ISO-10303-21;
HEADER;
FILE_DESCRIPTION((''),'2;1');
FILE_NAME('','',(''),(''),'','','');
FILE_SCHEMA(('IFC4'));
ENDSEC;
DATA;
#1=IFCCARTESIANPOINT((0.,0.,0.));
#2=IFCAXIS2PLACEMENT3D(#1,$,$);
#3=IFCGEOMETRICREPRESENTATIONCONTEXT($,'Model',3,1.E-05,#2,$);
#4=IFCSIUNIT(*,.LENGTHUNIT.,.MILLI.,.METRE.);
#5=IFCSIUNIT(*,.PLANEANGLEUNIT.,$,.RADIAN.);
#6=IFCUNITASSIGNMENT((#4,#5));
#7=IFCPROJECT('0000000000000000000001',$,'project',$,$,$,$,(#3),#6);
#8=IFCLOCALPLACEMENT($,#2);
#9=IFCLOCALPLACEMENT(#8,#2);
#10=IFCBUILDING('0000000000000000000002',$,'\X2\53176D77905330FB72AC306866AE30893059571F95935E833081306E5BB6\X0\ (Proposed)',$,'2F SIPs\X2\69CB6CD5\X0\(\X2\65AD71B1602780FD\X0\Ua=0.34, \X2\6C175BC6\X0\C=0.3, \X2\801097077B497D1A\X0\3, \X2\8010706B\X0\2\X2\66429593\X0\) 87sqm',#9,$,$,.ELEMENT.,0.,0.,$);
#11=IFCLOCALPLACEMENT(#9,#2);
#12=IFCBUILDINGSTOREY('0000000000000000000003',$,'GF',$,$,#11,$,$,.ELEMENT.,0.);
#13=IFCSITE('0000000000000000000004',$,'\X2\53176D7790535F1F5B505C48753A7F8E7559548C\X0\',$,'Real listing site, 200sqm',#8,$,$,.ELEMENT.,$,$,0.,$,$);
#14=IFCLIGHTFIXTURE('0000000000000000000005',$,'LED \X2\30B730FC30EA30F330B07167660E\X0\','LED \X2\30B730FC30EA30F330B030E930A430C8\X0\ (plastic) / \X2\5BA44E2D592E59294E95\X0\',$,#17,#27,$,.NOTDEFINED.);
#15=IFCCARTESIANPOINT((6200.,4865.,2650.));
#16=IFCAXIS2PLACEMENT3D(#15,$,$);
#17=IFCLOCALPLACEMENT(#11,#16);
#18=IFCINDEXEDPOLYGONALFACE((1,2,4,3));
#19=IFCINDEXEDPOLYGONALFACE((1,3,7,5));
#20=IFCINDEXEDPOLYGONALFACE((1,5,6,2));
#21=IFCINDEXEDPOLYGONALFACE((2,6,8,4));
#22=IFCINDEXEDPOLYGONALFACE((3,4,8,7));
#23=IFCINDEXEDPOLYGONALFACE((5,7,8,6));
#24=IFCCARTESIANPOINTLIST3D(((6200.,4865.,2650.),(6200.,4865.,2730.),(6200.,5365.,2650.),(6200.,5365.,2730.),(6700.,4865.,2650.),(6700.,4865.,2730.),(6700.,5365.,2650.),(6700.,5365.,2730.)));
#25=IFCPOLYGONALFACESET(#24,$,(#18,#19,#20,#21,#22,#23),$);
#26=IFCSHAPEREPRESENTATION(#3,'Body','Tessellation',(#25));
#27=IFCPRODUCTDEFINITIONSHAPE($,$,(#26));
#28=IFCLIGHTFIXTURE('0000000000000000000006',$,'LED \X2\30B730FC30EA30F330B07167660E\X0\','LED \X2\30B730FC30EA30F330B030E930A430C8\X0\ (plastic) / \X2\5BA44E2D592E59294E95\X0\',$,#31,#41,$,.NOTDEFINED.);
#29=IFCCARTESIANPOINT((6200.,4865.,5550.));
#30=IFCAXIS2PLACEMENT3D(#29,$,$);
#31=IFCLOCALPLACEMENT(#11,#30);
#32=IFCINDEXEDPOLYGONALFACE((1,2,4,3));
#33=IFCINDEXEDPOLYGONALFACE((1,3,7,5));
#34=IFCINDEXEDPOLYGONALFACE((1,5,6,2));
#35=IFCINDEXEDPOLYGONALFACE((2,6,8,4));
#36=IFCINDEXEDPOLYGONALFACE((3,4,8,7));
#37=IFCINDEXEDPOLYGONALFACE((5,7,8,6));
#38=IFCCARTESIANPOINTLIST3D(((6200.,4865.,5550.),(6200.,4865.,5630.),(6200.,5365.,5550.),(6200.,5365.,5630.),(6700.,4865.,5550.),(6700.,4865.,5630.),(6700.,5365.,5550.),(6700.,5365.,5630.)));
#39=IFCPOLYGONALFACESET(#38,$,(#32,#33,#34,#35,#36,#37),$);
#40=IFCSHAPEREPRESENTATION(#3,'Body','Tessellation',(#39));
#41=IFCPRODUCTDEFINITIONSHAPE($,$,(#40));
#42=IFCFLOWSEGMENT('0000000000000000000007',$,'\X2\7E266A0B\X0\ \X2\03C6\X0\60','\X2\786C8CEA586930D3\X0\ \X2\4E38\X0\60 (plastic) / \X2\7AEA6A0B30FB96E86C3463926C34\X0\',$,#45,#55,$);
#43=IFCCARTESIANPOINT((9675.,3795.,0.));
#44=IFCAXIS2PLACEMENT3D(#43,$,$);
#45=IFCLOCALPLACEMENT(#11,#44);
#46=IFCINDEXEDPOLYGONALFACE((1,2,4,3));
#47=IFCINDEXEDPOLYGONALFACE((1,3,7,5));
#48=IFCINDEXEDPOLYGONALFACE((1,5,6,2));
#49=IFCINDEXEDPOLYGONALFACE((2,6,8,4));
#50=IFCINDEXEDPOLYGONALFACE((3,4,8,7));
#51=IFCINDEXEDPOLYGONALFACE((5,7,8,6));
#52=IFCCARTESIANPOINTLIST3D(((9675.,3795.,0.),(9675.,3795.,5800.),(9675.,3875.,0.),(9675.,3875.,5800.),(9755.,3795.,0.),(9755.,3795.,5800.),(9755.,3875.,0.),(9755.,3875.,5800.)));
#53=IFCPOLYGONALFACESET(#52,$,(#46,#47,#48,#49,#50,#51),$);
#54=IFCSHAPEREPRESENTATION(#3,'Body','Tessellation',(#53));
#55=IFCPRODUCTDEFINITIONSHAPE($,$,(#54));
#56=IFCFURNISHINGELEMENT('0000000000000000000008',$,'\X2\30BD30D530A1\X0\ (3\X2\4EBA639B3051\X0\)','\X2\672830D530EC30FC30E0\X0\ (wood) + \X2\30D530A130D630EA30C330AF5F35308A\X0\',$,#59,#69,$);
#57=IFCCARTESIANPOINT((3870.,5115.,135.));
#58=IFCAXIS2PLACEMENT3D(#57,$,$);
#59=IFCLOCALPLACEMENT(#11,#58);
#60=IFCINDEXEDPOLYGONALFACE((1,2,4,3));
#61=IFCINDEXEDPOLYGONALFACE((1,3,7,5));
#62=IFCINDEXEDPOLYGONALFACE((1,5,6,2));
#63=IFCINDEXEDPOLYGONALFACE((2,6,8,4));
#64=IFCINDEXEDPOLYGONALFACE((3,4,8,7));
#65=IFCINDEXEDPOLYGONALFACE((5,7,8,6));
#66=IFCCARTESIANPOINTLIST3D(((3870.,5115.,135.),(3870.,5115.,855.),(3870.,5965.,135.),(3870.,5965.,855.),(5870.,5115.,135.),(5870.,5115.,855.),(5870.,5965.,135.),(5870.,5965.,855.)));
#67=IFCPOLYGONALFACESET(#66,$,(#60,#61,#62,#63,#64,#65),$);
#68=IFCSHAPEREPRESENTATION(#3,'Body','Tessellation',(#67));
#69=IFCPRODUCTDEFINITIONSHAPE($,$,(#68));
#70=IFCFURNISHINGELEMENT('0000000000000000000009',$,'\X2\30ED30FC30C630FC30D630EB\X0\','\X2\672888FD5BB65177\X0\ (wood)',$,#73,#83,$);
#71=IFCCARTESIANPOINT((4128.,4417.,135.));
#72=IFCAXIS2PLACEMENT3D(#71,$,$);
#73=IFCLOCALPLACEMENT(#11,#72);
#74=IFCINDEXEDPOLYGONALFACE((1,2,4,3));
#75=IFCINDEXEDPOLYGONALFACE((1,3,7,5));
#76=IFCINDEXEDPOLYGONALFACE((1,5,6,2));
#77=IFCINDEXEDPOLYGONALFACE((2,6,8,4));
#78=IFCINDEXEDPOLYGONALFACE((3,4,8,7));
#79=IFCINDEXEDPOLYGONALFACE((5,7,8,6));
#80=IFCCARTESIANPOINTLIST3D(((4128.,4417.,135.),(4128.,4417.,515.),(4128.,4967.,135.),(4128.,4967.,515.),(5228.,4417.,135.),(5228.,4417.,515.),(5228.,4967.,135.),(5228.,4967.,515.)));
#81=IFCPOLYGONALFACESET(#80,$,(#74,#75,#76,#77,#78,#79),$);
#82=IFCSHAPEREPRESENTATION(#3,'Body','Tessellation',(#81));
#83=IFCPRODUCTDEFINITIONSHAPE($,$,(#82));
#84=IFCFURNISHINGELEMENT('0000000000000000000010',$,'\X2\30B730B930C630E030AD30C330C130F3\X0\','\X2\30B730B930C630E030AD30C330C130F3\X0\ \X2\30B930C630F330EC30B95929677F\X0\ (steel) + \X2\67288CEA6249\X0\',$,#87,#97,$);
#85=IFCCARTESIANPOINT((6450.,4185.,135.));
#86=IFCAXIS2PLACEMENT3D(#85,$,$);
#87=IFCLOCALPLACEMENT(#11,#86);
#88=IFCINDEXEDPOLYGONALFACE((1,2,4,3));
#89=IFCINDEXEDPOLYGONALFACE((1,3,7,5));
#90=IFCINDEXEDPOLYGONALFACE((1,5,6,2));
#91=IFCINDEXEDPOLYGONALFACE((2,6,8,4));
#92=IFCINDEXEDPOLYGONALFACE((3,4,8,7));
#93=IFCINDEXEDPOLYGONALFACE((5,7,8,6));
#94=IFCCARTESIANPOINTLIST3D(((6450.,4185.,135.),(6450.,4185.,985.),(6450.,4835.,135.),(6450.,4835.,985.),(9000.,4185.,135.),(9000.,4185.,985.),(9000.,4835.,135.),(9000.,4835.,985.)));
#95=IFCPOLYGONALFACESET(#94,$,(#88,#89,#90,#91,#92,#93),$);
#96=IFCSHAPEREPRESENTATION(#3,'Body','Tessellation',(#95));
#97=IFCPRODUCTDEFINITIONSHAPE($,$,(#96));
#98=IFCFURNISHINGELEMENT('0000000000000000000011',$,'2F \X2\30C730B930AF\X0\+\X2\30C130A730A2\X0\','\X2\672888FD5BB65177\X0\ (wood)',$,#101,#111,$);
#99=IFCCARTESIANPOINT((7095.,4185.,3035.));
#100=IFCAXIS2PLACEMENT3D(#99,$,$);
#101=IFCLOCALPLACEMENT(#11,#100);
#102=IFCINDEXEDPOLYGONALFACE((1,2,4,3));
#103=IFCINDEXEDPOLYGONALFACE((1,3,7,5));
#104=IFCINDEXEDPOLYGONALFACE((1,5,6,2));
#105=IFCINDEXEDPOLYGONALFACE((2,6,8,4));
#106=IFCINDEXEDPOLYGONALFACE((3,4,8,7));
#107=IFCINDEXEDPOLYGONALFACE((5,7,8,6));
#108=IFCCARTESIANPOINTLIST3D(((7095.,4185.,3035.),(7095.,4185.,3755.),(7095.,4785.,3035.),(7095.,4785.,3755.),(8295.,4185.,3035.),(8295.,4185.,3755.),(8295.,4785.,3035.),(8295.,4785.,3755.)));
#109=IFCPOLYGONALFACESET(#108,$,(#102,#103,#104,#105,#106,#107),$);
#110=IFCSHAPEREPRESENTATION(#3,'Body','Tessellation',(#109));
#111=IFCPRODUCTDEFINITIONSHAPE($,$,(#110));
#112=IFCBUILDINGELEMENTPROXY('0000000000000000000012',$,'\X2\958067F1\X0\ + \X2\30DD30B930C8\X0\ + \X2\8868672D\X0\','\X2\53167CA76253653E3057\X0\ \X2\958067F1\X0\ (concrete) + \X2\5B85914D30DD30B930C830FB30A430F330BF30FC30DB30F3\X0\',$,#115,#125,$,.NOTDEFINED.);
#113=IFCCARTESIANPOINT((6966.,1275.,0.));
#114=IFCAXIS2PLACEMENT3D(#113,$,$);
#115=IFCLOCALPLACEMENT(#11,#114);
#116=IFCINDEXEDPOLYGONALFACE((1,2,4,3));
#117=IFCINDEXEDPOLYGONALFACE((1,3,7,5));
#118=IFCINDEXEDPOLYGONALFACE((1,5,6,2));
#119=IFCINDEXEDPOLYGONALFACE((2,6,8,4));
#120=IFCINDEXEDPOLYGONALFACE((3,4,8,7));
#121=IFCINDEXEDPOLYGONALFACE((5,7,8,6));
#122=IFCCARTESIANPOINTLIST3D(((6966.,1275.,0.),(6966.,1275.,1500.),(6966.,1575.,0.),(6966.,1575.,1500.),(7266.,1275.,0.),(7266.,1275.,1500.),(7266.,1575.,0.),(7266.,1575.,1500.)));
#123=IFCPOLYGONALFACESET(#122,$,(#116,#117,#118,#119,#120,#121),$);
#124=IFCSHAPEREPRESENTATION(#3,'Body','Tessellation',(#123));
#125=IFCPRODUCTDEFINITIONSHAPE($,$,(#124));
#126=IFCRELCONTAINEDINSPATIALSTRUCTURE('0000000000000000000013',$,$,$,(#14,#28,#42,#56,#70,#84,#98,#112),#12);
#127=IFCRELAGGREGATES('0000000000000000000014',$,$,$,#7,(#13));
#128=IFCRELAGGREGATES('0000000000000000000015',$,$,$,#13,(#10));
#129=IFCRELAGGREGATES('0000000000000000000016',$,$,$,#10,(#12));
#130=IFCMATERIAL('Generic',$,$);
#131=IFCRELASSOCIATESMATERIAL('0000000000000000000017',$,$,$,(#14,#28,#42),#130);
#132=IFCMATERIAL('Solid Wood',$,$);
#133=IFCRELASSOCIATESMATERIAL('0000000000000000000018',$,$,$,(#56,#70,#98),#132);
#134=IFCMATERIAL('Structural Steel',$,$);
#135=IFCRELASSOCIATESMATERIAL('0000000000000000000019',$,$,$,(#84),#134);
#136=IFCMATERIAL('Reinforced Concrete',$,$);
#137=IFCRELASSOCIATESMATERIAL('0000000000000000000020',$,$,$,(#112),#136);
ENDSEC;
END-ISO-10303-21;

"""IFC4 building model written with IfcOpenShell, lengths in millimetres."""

from ifc_helpers import new_model, si_unit, frame, frame_2d, origin, place, context, project, spatial, rectangle, extrude, material, element, save


model = new_model("IFC4")

# Units and contexts
model_context = context("Model", 3, precision=1e-05, world=origin())
ifc_project = project(units=[si_unit("LENGTHUNIT", "METRE", prefix="MILLI"), si_unit("PLANEANGLEUNIT", "RADIAN")], contexts=[model_context])

# Site, building, storey
site_placement = place(None, origin())
site = spatial("IfcSite", under=ifc_project, at=site_placement, Name="北海道弟子屈町美留和", ObjectType="Real listing site, 200sqm", CompositionType="ELEMENT", RefElevation=0.0)
building_placement = place(site_placement, origin())
building = spatial("IfcBuilding", under=site, at=building_placement, Name="北海道・犬と暮らす土間広めの家 (Proposed)", ObjectType="2F SIPs構法(断熱性能Ua=0.34, 気密C=0.3, 耐震等級3, 耐火2時間) 87sqm", CompositionType="ELEMENT", ElevationOfRefHeight=0.0, ElevationOfTerrain=0.0)
storey_placement = place(building_placement, origin())
storey = spatial("IfcBuildingStorey", under=building, at=storey_placement, Name="GF", CompositionType="ELEMENT", Elevation=0.0)

# Shared definitions
ifc_material_1 = material(Name="Solid Wood")

# Shared definitions
ifc_material_2 = material(Name="Reinforced Concrete")

# Shared definitions
ifc_material_3 = material(Name="Structural Steel")

# Shared definitions
ifc_material_4 = material(Name="Generic")

# Light fixtures
light_fixture_1_placement = place(storey_placement, frame((6200.0, 4865.0, 2650.0)))
element("IfcLightFixture", 1, at=light_fixture_1_placement, inside=storey, material=ifc_material_4, Name="LED シーリング照明", Description="LED シーリングライト (plastic) / 室中央天井", PredefinedType="NOTDEFINED", context=model_context, shape_type="SweptSolid", body=[
    extrude(rectangle(XDim=500.0, YDim=500.0, at=frame_2d((250.0, 250.0))), frame((6200.0, 4865.0, 2650.0)), (0.0, 0.0, 1.0), 80.0),
])
light_fixture_2_placement = place(storey_placement, frame((6200.0, 4865.0, 5550.0)))
element("IfcLightFixture", 2, at=light_fixture_2_placement, inside=storey, material=ifc_material_4, Name="LED シーリング照明", Description="LED シーリングライト (plastic) / 室中央天井", PredefinedType="NOTDEFINED", context=model_context, shape_type="SweptSolid", body=[
    extrude(rectangle(XDim=500.0, YDim=500.0, at=frame_2d((250.0, 250.0))), frame((6200.0, 4865.0, 5550.0)), (0.0, 0.0, 1.0), 80.0),
])

# Flow segment
flow_segment_placement = place(storey_placement, frame((9675.0, 3795.0, 0.0)))
element("IfcFlowSegment", 3, at=flow_segment_placement, inside=storey, material=ifc_material_4, Name="縦樋 φ60", Description="硬質塩ビ 丸60 (plastic) / 竪樋・雨水排水", context=model_context, shape_type="SweptSolid", body=[
    extrude(rectangle(XDim=80.0, YDim=80.0, at=frame_2d((40.0, 40.0))), frame((9675.0, 3795.0, 0.0)), (0.0, 0.0, 1.0), 5800.0),
])

# Furnishing elements
furnishing_1_placement = place(storey_placement, frame((3870.0, 5115.0, 135.0)))
element("IfcFurnishingElement", 4, at=furnishing_1_placement, inside=storey, material=ifc_material_1, Name="ソファ (3人掛け)", Description="木フレーム (wood) + ファブリック張り", context=model_context, shape_type="SweptSolid", body=[
    extrude(rectangle(XDim=2000.0, YDim=850.0, at=frame_2d((1000.0, 425.0))), frame((3870.0, 5115.0, 135.0)), (0.0, 0.0, 1.0), 720.0),
])
furnishing_2_placement = place(storey_placement, frame((4128.0, 4417.0, 135.0)))
element("IfcFurnishingElement", 5, at=furnishing_2_placement, inside=storey, material=ifc_material_1, Name="ローテーブル", Description="木製家具 (wood)", context=model_context, shape_type="SweptSolid", body=[
    extrude(rectangle(XDim=1100.0, YDim=550.0, at=frame_2d((550.0, 275.0))), frame((4128.0, 4417.0, 135.0)), (0.0, 0.0, 1.0), 380.0),
])
furnishing_3_placement = place(storey_placement, frame((6450.0, 4185.0, 135.0)))
element("IfcFurnishingElement", 6, at=furnishing_3_placement, inside=storey, material=ifc_material_3, Name="システムキッチン", Description="システムキッチン ステンレス天板 (steel) + 木質扉", context=model_context, shape_type="SweptSolid", body=[
    extrude(rectangle(XDim=2550.0, YDim=650.0, at=frame_2d((1275.0, 325.0))), frame((6450.0, 4185.0, 135.0)), (0.0, 0.0, 1.0), 850.0),
])
furnishing_4_placement = place(storey_placement, frame((7095.0, 4185.0, 3035.0)))
element("IfcFurnishingElement", 7, at=furnishing_4_placement, inside=storey, material=ifc_material_1, Name="2F デスク+チェア", Description="木製家具 (wood)", context=model_context, shape_type="SweptSolid", body=[
    extrude(rectangle(XDim=1200.0, YDim=600.0, at=frame_2d((600.0, 300.0))), frame((7095.0, 4185.0, 3035.0)), (0.0, 0.0, 1.0), 720.0),
])

# Building element proxy
proxy_placement = place(storey_placement, frame((6966.0, 1275.0, 0.0)))
element("IfcBuildingElementProxy", 8, at=proxy_placement, inside=storey, material=ifc_material_2, Name="門柱 + ポスト + 表札", Description="化粧打放し 門柱 (concrete) + 宅配ポスト・インターホン", PredefinedType="NOTDEFINED", context=model_context, shape_type="SweptSolid", body=[
    extrude(rectangle(XDim=300.0, YDim=300.0, at=frame_2d((150.0, 150.0))), frame((6966.0, 1275.0, 0.0)), (0.0, 0.0, 1.0), 1500.0),
])

save(model, "model.ifc")
